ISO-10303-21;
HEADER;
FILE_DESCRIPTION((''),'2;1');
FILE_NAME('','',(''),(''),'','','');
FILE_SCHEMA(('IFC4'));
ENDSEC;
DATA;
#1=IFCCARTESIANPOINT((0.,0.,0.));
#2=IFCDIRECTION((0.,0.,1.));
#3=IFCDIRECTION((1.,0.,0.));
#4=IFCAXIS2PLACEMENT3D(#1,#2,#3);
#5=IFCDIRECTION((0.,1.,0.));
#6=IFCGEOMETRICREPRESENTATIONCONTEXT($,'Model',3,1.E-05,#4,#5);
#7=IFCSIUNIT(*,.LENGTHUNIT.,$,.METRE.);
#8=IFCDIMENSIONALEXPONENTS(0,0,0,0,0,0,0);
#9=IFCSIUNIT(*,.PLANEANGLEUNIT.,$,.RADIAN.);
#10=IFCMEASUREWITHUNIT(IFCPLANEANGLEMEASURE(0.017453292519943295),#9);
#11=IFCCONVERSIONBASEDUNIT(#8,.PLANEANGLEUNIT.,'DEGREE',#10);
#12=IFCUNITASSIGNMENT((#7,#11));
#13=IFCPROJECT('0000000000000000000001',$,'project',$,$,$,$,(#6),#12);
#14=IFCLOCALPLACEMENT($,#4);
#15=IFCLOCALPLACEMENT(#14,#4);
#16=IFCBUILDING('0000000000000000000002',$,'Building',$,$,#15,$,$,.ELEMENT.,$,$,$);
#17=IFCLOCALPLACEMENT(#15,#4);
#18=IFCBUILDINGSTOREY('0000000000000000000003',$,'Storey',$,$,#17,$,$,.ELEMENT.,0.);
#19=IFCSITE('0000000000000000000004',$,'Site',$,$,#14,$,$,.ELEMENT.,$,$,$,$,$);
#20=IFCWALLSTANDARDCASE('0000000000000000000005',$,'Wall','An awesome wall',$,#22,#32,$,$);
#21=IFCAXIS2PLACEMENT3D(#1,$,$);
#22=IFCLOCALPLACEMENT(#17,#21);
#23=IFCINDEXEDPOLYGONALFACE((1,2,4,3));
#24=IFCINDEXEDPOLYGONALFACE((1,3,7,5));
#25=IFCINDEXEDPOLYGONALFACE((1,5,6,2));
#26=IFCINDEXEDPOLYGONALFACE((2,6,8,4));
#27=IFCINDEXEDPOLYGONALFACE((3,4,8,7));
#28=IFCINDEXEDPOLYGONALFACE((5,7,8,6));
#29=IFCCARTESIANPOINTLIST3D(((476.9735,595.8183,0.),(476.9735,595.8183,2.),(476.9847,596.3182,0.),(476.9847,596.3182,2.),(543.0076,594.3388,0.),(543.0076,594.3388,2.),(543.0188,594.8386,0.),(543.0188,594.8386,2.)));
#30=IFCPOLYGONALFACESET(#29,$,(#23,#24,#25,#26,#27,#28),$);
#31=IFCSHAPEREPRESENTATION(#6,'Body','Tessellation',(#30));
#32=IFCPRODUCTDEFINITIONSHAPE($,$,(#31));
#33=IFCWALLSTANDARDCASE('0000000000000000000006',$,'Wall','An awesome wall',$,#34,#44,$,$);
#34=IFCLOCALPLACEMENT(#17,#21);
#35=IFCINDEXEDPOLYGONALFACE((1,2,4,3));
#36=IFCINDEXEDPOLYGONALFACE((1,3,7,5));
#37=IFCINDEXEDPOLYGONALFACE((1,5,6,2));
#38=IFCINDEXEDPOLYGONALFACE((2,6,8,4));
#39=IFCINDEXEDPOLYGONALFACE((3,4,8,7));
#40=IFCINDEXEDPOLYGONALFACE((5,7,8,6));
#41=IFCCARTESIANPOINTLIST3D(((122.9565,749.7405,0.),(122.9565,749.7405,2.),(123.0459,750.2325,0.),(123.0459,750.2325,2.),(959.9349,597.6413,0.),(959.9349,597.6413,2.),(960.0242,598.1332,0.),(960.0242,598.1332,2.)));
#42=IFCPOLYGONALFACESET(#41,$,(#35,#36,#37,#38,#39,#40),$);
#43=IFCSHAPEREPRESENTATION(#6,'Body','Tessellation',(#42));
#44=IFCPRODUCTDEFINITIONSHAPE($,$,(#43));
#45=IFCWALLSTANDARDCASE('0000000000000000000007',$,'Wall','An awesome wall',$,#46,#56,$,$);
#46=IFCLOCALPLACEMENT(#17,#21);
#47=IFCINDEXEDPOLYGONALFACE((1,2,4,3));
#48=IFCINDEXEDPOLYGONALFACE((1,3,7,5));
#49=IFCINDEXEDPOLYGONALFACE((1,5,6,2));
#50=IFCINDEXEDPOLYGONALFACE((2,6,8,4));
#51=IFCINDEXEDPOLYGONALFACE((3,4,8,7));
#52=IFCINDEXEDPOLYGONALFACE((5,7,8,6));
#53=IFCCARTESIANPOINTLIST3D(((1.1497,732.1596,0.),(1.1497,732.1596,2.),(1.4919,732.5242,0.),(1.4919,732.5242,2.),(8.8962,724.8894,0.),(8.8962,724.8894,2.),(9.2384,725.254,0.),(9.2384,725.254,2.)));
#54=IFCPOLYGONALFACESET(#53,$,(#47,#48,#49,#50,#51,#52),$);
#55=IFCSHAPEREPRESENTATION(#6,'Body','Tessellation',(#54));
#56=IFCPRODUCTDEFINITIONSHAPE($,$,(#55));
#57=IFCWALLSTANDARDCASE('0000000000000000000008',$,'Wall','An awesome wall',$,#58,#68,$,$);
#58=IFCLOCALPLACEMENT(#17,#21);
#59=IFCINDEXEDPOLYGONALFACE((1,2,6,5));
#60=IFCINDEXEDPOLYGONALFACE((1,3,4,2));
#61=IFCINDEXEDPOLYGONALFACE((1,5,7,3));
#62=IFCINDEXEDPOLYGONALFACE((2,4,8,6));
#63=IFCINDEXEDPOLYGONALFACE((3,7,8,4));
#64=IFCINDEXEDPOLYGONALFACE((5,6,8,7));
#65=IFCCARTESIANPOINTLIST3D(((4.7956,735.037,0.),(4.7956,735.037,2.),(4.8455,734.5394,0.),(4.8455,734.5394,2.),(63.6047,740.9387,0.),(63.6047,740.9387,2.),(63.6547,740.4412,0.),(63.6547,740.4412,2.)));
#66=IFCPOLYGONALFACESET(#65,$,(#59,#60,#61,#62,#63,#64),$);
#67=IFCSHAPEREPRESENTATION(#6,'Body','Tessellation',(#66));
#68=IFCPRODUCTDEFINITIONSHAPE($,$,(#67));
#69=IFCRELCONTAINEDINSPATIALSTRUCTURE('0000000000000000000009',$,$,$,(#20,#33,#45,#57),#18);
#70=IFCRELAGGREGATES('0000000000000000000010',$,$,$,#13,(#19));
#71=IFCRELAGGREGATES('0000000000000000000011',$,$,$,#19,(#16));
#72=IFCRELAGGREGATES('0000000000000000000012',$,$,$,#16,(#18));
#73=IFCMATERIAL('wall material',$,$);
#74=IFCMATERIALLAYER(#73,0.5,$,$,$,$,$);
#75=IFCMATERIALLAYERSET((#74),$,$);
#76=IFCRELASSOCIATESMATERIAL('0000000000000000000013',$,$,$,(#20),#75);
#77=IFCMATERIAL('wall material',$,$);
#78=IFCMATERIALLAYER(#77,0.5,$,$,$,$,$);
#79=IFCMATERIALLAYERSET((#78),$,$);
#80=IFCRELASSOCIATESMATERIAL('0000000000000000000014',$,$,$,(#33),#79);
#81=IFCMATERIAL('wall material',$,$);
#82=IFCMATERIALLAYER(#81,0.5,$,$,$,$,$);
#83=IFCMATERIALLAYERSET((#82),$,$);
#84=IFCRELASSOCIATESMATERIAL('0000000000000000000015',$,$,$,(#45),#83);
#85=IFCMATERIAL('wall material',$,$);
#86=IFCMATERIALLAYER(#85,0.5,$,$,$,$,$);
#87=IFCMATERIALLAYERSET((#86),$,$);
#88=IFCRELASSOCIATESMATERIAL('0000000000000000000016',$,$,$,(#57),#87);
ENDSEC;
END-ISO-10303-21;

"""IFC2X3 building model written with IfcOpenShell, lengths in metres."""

from ifc_helpers import new_model, entity, si_unit, converted_unit, direction, frame, origin_with_axes, place, context, project, spatial, polyline, outline, extrude, material, layer, layer_set, layer_usage, element, save


model = new_model("IFC2X3")

# Units and contexts
model_context = context("Model", 3, precision=1e-05, world=origin_with_axes(), true_north=direction((0.0, 1.0, 0.0)))
ifc_project = project(units=[si_unit("LENGTHUNIT", "METRE"), converted_unit("PLANEANGLEUNIT", "DEGREE", entity("IfcPlaneAngleMeasure", 0.017453292519943295), si_unit("PLANEANGLEUNIT", "RADIAN"), dimensions=[0, 0, 0, 0, 0, 0, 0])], contexts=[model_context])

# Site, building, storey
site_placement = place(None, origin_with_axes())
site = spatial("IfcSite", under=ifc_project, at=site_placement, Name="Site", CompositionType="ELEMENT")
building_placement = place(site_placement, origin_with_axes())
building = spatial("IfcBuilding", under=site, at=building_placement, Name="Building", CompositionType="ELEMENT")
storey_placement = place(building_placement, origin_with_axes())
storey = spatial("IfcBuildingStorey", under=building, at=storey_placement, Name="Storey", CompositionType="ELEMENT", Elevation=0.0)

# Walls
ifc_material_1 = material(Name="wall material")
ifc_layer_1 = layer(ifc_material_1, 0.5)
ifc_layer_set_1 = layer_set([ifc_layer_1])
ifc_layer_usage_1 = layer_usage(ifc_layer_set_1, "AXIS2", "POSITIVE", -0.1)
wall_1_placement = place(storey_placement, origin_with_axes())
element("IfcWallStandardCase", 1, at=wall_1_placement, inside=storey, material=ifc_layer_usage_1, Name="Wall", Description="An awesome wall", context=model_context, shape_type="SweptSolid", body=[
    extrude(outline(polyline([(0.0, -0.25, 0.0), (66.0506, -0.25, 0.0), (66.0506, 0.25, 0.0), (0.0, 0.25, 0.0), (0.0, -0.25, 0.0)])), frame((543.0132, 594.5887, 0.0), z_axis=(0.0, 0.0, 1.0), x_axis=(-66.03407, 1.47954, 0.0)), (0.0, 0.0, 1.0), 2.0),
])
ifc_material_2 = material(Name="wall material")
ifc_layer_2 = layer(ifc_material_2, 0.5)
ifc_layer_set_2 = layer_set([ifc_layer_2])
ifc_layer_usage_2 = layer_usage(ifc_layer_set_2, "AXIS2", "POSITIVE", -0.1)
wall_2_placement = place(storey_placement, origin_with_axes())
element("IfcWallStandardCase", 2, at=wall_2_placement, inside=storey, material=ifc_layer_usage_2, Name="Wall", Description="An awesome wall", context=model_context, shape_type="SweptSolid", body=[
    extrude(outline(polyline([(0.0, -0.25, 0.0), (850.6861, -0.25, 0.0), (850.6861, 0.25, 0.0), (0.0, 0.25, 0.0), (0.0, -0.25, 0.0)])), frame((959.9796, 597.8873, 0.0), z_axis=(0.0, 0.0, 1.0), x_axis=(-836.97831, 152.09923, 0.0)), (0.0, 0.0, 1.0), 2.0),
])
ifc_material_3 = material(Name="wall material")
ifc_layer_3 = layer(ifc_material_3, 0.5)
ifc_layer_set_3 = layer_set([ifc_layer_3])
ifc_layer_usage_3 = layer_usage(ifc_layer_set_3, "AXIS2", "POSITIVE", -0.1)
wall_3_placement = place(storey_placement, origin_with_axes())
element("IfcWallStandardCase", 3, at=wall_3_placement, inside=storey, material=ifc_layer_usage_3, Name="Wall", Description="An awesome wall", context=model_context, shape_type="SweptSolid", body=[
    extrude(outline(polyline([(0.0, -0.25, 0.0), (10.6237, -0.25, 0.0), (10.6237, 0.25, 0.0), (0.0, 0.25, 0.0), (0.0, -0.25, 0.0)])), frame((9.0673, 725.0717, 0.0), z_axis=(0.0, 0.0, 1.0), x_axis=(-7.746487, 7.27016, 0.0)), (0.0, 0.0, 1.0), 2.0),
])
ifc_material_4 = material(Name="wall material")
ifc_layer_4 = layer(ifc_material_4, 0.5)
ifc_layer_set_4 = layer_set([ifc_layer_4])
ifc_layer_usage_4 = layer_usage(ifc_layer_set_4, "AXIS2", "POSITIVE", -0.1)
wall_4_placement = place(storey_placement, origin_with_axes())
element("IfcWallStandardCase", 4, at=wall_4_placement, inside=storey, material=ifc_layer_usage_4, Name="Wall", Description="An awesome wall", context=model_context, shape_type="SweptSolid", body=[
    extrude(outline(polyline([(0.0, -0.25, 0.0), (59.1045, -0.25, 0.0), (59.1045, 0.25, 0.0), (0.0, 0.25, 0.0), (0.0, -0.25, 0.0)])), frame((4.8205, 734.7882, 0.0), z_axis=(0.0, 0.0, 1.0), x_axis=(58.809149, 5.90174, 0.0)), (0.0, 0.0, 1.0), 2.0),
])

save(model, "model.ifc")
